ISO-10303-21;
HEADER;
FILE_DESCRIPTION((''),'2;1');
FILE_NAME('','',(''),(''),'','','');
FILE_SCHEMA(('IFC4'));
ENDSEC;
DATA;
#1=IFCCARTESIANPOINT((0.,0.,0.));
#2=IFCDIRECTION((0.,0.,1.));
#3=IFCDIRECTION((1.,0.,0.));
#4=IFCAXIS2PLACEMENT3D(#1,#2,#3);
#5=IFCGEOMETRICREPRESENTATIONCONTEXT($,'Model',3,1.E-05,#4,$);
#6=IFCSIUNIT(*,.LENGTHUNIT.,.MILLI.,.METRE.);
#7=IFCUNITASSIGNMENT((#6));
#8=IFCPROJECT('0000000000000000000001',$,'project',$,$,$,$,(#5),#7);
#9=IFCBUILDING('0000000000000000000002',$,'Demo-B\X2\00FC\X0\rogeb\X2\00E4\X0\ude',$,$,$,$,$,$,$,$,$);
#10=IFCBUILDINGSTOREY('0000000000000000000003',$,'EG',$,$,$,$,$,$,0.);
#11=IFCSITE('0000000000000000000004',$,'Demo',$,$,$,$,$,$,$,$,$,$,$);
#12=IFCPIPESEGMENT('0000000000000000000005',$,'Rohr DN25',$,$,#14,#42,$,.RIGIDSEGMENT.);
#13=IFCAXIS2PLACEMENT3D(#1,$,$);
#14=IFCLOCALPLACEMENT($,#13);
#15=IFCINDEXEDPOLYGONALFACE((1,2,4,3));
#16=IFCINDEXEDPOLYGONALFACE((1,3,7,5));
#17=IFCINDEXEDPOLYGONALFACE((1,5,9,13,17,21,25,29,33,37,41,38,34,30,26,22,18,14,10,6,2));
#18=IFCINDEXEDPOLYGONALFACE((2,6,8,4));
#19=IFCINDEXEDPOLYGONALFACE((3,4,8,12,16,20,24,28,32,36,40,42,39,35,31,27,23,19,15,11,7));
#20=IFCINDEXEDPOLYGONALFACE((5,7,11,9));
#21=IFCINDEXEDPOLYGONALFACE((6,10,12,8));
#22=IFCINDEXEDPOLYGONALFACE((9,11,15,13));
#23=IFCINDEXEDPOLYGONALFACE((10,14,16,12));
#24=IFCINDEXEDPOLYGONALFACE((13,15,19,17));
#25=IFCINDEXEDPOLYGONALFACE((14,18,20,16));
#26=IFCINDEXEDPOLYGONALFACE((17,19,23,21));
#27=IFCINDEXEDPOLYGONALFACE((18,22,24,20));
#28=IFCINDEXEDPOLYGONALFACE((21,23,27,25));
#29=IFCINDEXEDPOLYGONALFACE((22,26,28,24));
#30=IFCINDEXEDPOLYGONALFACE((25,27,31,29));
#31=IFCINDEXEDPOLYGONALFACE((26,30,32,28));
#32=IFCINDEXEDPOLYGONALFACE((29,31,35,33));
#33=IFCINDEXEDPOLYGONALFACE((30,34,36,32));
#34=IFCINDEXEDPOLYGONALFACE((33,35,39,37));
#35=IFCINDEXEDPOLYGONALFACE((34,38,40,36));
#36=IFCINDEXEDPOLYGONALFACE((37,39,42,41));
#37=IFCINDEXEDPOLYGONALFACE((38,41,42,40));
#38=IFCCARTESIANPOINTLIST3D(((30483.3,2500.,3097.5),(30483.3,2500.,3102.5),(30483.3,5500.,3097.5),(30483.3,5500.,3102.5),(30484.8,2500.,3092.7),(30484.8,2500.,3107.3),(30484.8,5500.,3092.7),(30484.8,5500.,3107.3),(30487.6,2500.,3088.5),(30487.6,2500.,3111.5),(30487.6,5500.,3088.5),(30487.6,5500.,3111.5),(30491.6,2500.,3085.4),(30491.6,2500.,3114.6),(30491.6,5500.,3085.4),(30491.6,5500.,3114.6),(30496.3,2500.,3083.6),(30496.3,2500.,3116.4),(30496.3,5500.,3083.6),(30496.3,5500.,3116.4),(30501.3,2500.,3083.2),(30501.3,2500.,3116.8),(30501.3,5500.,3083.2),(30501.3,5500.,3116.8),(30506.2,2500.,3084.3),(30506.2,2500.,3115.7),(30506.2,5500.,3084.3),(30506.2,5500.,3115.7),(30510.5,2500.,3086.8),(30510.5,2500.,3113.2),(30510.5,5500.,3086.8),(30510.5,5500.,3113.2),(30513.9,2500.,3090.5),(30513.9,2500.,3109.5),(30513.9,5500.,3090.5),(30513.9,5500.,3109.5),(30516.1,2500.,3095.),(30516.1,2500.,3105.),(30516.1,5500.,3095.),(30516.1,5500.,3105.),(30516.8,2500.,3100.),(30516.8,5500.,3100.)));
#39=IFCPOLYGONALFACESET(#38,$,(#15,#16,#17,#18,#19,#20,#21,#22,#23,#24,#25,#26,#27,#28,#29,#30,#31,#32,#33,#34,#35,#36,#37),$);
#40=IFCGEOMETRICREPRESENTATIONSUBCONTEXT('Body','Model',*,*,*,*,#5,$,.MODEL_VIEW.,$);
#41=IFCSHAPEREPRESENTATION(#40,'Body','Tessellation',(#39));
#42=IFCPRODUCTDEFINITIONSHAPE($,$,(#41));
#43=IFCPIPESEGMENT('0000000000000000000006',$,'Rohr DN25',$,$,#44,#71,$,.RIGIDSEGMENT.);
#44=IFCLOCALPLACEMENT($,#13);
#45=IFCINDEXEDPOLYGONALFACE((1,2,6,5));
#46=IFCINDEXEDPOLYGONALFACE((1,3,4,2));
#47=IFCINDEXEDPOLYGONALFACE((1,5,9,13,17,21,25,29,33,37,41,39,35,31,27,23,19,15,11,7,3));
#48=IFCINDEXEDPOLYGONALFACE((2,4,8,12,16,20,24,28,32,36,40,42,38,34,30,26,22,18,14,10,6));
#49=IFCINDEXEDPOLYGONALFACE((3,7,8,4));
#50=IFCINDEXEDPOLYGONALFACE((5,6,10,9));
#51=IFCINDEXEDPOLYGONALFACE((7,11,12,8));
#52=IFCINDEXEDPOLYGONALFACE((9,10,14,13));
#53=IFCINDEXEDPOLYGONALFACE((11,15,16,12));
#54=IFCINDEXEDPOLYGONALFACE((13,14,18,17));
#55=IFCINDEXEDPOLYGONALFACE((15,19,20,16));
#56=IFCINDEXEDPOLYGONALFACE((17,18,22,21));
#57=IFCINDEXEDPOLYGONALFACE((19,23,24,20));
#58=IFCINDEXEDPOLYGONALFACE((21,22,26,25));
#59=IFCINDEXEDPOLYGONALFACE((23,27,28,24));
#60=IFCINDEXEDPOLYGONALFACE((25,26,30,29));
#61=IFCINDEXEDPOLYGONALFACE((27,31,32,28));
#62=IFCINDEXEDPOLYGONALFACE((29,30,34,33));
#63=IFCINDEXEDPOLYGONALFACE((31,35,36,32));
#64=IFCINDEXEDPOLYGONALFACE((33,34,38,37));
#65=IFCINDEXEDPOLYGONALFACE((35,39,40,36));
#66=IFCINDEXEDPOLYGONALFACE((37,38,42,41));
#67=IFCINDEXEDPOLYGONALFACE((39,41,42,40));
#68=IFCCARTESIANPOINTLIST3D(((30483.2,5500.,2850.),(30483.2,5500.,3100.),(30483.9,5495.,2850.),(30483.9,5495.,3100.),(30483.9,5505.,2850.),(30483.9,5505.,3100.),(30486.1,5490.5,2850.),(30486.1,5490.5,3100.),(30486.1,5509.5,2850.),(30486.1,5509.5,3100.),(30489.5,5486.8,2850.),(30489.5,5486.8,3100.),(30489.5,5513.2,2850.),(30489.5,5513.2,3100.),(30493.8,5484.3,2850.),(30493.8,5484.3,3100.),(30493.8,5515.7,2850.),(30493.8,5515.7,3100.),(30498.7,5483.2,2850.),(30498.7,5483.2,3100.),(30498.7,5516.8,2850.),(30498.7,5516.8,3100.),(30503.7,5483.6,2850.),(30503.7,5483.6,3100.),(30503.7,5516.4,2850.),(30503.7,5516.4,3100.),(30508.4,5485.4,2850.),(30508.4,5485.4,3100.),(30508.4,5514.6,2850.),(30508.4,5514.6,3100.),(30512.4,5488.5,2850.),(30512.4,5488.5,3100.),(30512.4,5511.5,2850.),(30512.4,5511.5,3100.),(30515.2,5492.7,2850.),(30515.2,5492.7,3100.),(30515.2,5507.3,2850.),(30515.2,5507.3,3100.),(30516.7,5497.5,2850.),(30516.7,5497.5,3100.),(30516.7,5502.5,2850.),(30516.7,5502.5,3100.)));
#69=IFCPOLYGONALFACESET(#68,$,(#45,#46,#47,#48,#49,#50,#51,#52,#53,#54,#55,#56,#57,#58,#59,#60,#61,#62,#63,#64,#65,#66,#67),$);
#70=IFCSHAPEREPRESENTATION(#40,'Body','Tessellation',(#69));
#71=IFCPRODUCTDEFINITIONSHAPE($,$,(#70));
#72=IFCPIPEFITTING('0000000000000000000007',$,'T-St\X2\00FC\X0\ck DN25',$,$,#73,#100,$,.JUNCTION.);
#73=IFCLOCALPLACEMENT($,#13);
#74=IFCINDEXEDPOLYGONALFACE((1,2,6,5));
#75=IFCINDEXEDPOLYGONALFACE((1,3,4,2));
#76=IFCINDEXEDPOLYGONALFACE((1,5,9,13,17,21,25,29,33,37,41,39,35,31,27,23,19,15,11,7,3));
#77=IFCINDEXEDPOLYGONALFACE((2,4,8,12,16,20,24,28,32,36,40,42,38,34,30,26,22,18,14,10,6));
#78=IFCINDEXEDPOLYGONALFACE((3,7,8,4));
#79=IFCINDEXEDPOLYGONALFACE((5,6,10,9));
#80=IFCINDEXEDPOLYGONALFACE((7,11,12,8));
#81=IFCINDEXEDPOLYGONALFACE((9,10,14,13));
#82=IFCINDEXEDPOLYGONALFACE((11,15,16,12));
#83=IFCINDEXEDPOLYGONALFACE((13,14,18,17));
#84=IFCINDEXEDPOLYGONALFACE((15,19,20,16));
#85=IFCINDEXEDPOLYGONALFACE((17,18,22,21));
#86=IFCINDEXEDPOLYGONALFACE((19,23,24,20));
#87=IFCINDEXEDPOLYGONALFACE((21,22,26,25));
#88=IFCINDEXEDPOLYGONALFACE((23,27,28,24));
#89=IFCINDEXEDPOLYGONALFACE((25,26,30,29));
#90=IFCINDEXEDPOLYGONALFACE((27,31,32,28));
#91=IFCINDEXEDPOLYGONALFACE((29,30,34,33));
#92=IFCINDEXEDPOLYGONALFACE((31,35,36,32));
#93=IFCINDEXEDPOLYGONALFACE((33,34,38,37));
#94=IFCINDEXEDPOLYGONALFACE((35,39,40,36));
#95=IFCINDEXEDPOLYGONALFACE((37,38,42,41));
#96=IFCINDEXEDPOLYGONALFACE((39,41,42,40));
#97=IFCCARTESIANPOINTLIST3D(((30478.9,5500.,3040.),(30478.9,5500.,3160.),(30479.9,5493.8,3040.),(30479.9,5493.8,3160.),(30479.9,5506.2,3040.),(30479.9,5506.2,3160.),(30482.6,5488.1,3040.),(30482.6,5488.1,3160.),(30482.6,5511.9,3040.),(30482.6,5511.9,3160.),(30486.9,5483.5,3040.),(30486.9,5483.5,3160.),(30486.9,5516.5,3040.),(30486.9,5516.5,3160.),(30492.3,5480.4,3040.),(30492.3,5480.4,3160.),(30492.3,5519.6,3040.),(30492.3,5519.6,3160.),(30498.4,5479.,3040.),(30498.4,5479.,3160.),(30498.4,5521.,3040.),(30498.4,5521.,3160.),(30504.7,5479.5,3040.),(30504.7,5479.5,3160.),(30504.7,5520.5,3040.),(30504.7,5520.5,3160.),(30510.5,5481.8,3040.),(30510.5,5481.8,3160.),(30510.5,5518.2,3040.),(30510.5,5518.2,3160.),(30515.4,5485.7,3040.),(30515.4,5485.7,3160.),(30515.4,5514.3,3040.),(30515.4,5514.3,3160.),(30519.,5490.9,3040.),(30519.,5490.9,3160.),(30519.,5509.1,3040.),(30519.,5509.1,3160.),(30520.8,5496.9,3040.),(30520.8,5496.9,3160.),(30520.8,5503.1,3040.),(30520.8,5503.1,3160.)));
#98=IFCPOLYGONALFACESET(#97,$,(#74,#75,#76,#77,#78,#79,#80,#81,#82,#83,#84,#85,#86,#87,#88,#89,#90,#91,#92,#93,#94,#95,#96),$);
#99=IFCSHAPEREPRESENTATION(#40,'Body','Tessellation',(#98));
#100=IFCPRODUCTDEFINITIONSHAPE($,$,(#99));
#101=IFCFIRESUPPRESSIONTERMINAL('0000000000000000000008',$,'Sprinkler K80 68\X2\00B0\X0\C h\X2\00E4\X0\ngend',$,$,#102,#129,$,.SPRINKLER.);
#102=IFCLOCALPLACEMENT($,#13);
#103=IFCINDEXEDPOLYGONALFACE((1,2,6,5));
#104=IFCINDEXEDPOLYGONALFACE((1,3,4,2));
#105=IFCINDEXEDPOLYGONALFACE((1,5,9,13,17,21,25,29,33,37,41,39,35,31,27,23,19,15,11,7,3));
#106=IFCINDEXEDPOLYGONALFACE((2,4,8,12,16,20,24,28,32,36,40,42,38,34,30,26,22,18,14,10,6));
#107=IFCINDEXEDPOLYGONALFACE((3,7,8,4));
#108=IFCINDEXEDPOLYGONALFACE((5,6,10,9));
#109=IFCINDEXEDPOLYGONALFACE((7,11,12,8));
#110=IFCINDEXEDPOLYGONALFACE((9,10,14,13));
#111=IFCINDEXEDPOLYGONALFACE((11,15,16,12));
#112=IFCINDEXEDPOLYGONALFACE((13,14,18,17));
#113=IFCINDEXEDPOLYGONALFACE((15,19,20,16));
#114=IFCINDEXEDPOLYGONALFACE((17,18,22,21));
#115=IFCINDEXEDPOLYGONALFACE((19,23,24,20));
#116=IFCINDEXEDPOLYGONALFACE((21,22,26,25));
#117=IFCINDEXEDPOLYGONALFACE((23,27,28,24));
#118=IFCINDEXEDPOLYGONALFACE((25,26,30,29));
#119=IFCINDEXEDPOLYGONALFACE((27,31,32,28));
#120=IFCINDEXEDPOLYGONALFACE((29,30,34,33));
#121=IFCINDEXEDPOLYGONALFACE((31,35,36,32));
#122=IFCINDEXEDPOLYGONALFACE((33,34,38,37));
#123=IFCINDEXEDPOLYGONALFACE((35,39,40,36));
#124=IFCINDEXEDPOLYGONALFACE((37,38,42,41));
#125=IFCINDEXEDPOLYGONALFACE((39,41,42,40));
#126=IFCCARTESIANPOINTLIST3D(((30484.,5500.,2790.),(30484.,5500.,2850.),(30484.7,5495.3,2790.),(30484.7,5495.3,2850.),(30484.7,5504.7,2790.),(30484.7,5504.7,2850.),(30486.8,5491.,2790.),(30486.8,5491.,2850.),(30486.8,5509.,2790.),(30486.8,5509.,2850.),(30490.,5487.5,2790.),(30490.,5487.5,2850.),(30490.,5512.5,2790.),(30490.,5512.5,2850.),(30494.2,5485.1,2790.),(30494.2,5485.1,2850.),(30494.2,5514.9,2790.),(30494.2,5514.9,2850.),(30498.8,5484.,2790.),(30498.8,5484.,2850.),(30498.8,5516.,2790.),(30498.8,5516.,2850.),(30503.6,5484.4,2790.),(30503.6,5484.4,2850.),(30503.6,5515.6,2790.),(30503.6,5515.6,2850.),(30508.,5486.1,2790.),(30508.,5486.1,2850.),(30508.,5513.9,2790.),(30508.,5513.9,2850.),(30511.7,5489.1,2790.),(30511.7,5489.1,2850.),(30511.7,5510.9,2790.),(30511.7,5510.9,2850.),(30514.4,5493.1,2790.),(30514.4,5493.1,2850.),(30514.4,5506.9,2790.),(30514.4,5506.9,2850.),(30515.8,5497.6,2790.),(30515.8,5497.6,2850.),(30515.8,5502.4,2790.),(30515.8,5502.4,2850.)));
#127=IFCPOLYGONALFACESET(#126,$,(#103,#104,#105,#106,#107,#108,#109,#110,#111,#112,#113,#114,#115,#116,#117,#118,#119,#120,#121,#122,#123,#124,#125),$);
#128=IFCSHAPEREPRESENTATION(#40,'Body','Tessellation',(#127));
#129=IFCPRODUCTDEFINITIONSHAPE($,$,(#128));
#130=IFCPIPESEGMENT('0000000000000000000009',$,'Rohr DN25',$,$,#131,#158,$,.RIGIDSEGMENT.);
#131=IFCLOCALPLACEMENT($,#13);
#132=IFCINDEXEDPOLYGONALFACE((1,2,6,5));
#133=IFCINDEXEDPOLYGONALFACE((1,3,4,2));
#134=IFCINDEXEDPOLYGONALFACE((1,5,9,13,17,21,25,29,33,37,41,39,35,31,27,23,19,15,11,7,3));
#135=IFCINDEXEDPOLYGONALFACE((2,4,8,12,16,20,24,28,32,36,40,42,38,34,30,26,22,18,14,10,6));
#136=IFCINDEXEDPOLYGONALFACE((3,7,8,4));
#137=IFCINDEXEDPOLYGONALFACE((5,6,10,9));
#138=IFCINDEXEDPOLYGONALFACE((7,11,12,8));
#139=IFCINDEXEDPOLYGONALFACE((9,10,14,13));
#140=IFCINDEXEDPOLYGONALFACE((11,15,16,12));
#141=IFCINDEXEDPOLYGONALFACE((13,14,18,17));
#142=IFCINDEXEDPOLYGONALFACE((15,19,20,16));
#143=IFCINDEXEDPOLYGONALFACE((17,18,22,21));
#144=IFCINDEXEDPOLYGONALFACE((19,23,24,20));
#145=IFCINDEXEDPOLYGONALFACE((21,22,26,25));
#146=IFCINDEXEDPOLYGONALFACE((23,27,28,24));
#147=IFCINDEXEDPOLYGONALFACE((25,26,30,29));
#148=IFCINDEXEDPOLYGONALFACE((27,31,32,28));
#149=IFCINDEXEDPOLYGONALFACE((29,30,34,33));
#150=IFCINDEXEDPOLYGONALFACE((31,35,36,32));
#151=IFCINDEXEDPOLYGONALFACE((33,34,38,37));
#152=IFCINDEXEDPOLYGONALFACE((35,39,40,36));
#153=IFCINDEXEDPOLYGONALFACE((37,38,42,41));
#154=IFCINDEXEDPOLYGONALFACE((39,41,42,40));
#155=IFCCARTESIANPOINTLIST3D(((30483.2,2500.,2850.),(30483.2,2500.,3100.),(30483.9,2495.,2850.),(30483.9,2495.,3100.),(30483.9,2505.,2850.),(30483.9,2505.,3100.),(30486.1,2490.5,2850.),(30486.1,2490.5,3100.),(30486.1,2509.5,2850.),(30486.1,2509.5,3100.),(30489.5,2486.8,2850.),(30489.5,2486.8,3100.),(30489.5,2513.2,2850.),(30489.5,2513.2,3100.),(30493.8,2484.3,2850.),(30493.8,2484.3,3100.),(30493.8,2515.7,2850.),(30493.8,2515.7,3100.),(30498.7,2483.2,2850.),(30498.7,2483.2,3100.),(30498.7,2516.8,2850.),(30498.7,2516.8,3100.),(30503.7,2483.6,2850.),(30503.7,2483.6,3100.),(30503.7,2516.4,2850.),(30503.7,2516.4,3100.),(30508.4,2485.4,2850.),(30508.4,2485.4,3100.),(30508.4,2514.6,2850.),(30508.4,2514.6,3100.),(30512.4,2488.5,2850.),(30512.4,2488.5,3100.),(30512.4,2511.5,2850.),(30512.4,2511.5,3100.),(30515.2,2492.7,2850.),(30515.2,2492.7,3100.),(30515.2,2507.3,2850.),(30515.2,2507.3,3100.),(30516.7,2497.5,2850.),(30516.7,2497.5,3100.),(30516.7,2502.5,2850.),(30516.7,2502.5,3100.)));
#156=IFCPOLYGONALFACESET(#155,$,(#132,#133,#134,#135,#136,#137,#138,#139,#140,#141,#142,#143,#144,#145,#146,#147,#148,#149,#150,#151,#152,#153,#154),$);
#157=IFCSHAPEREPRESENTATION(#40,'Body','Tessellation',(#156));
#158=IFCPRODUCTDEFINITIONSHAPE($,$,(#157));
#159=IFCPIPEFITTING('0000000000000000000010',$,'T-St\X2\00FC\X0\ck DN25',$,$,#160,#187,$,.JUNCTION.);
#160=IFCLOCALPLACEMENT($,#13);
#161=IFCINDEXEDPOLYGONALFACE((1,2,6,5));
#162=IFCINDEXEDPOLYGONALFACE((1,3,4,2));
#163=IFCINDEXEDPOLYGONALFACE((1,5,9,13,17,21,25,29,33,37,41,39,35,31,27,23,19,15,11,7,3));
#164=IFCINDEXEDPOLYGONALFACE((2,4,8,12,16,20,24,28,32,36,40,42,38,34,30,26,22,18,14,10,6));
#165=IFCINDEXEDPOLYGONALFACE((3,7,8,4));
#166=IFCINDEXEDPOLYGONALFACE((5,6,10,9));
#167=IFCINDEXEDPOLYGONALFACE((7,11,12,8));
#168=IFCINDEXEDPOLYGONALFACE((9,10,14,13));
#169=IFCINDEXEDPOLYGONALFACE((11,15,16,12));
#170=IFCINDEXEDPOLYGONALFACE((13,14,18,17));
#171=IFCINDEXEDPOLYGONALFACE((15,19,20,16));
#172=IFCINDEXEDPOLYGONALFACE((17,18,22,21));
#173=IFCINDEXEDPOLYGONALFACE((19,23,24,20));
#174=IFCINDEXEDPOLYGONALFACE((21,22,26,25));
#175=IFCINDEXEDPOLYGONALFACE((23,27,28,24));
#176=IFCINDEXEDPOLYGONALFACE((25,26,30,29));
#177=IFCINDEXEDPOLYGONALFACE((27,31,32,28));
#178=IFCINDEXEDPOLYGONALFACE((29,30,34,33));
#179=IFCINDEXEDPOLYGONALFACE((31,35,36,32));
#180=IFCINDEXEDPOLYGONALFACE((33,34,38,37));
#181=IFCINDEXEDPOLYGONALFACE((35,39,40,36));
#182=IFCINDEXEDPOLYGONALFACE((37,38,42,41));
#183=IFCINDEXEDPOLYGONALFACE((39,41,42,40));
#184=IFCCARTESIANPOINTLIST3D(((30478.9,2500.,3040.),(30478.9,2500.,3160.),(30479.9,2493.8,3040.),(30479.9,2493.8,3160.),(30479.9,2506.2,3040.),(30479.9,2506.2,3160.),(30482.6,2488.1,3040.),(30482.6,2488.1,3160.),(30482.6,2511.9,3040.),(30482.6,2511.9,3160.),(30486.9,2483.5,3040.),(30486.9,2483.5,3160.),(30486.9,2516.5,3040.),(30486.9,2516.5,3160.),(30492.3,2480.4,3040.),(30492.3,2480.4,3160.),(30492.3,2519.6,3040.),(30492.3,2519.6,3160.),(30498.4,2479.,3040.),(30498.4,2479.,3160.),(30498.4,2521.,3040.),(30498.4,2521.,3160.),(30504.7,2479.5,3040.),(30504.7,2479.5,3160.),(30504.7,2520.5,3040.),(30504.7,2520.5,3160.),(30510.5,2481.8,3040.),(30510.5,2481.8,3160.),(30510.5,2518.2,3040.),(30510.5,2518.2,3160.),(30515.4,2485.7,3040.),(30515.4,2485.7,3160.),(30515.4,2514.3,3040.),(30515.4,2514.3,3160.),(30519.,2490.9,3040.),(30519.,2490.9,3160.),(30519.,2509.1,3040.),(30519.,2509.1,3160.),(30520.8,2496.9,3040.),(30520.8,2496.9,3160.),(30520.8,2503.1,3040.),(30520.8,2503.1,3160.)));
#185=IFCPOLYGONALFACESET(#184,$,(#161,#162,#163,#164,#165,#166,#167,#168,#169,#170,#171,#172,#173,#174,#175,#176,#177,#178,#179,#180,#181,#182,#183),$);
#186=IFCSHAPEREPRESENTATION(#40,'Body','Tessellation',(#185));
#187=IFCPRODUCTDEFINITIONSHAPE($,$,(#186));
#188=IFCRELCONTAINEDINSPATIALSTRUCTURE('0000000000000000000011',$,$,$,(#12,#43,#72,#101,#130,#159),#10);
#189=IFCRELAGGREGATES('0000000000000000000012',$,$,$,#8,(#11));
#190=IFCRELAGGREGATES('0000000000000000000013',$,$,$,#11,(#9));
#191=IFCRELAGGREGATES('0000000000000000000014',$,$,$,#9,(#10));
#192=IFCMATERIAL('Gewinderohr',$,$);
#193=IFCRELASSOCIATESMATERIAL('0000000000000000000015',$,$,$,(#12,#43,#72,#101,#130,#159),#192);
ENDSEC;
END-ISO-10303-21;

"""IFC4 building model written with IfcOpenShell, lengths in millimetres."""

from ifc_helpers import new_model, si_unit, frame, origin_with_axes, place, context, subcontext, project, spatial, circle, extrude, material, element, save


model = new_model("IFC4")

# Units and contexts
model_context = context("Model", 3, precision=1e-05, world=origin_with_axes())
body_context = subcontext(model_context, "Body", "Model", "MODEL_VIEW")
ifc_project = project(units=[si_unit("LENGTHUNIT", "METRE", prefix="MILLI")], contexts=[model_context])

# Site, building, storey
site = spatial("IfcSite", under=ifc_project, Name="Demo")
building = spatial("IfcBuilding", under=site, Name="Demo-Bürogebäude")
storey = spatial("IfcBuildingStorey", under=building, Name="EG", Elevation=0.0)

# Pipe segments
ifc_material_1 = material(Name="Gewinderohr")
pipe_segment_1_placement = place(None, frame((30500.0, 5500.0, 3100.0), z_axis=(0.0, -1.0, 0.0), x_axis=(1.0, 0.0, 0.0)))
element("IfcPipeSegment", 1, at=pipe_segment_1_placement, inside=storey, material=ifc_material_1, Name="Rohr DN25", PredefinedType="RIGIDSEGMENT", context=body_context, shape_type="SweptSolid", body=[
    extrude(circle(Radius=16.9), origin_with_axes(), (0.0, 0.0, 1.0), 3000.0),
])
pipe_segment_2_placement = place(None, frame((30500.0, 5500.0, 3100.0), z_axis=(0.0, 0.0, -1.0), x_axis=(-1.0, 0.0, 0.0)))
element("IfcPipeSegment", 2, at=pipe_segment_2_placement, inside=storey, material=ifc_material_1, Name="Rohr DN25", PredefinedType="RIGIDSEGMENT", context=body_context, shape_type="SweptSolid", body=[
    extrude(circle(Radius=16.9), origin_with_axes(), (0.0, 0.0, 1.0), 250.0),
])

# Pipe fitting
pipe_fitting_1_placement = place(None, frame((30500.0, 5500.0, 3160.0), z_axis=(0.0, 0.0, -1.0), x_axis=(-1.0, 0.0, 0.0)))
element("IfcPipeFitting", 3, at=pipe_fitting_1_placement, inside=storey, material=ifc_material_1, Name="T-Stück DN25", PredefinedType="JUNCTION", context=body_context, shape_type="SweptSolid", body=[
    extrude(circle(Radius=21.1), origin_with_axes(), (0.0, 0.0, 1.0), 120.0),
])

# Fire suppression terminal
fire_suppression_terminal_1_placement = place(None, frame((30500.0, 5500.0, 2850.0), z_axis=(0.0, 0.0, -1.0), x_axis=(-1.0, 0.0, 0.0)))
element("IfcFireSuppressionTerminal", 4, at=fire_suppression_terminal_1_placement, inside=storey, material=ifc_material_1, Name="Sprinkler K80 68°C hängend", PredefinedType="SPRINKLER", context=body_context, shape_type="SweptSolid", body=[
    extrude(circle(Radius=16.0), origin_with_axes(), (0.0, 0.0, 1.0), 60.0),
])

# Pipe segment
pipe_segment_3_placement = place(None, frame((30500.0, 2500.0, 3100.0), z_axis=(0.0, 0.0, -1.0), x_axis=(-1.0, 0.0, 0.0)))
element("IfcPipeSegment", 5, at=pipe_segment_3_placement, inside=storey, material=ifc_material_1, Name="Rohr DN25", PredefinedType="RIGIDSEGMENT", context=body_context, shape_type="SweptSolid", body=[
    extrude(circle(Radius=16.9), origin_with_axes(), (0.0, 0.0, 1.0), 250.0),
])

# Pipe fitting
pipe_fitting_2_placement = place(None, frame((30500.0, 2500.0, 3160.0), z_axis=(0.0, 0.0, -1.0), x_axis=(-1.0, 0.0, 0.0)))
element("IfcPipeFitting", 6, at=pipe_fitting_2_placement, inside=storey, material=ifc_material_1, Name="T-Stück DN25", PredefinedType="JUNCTION", context=body_context, shape_type="SweptSolid", body=[
    extrude(circle(Radius=21.1), origin_with_axes(), (0.0, 0.0, 1.0), 120.0),
])

save(model, "model.ifc")
